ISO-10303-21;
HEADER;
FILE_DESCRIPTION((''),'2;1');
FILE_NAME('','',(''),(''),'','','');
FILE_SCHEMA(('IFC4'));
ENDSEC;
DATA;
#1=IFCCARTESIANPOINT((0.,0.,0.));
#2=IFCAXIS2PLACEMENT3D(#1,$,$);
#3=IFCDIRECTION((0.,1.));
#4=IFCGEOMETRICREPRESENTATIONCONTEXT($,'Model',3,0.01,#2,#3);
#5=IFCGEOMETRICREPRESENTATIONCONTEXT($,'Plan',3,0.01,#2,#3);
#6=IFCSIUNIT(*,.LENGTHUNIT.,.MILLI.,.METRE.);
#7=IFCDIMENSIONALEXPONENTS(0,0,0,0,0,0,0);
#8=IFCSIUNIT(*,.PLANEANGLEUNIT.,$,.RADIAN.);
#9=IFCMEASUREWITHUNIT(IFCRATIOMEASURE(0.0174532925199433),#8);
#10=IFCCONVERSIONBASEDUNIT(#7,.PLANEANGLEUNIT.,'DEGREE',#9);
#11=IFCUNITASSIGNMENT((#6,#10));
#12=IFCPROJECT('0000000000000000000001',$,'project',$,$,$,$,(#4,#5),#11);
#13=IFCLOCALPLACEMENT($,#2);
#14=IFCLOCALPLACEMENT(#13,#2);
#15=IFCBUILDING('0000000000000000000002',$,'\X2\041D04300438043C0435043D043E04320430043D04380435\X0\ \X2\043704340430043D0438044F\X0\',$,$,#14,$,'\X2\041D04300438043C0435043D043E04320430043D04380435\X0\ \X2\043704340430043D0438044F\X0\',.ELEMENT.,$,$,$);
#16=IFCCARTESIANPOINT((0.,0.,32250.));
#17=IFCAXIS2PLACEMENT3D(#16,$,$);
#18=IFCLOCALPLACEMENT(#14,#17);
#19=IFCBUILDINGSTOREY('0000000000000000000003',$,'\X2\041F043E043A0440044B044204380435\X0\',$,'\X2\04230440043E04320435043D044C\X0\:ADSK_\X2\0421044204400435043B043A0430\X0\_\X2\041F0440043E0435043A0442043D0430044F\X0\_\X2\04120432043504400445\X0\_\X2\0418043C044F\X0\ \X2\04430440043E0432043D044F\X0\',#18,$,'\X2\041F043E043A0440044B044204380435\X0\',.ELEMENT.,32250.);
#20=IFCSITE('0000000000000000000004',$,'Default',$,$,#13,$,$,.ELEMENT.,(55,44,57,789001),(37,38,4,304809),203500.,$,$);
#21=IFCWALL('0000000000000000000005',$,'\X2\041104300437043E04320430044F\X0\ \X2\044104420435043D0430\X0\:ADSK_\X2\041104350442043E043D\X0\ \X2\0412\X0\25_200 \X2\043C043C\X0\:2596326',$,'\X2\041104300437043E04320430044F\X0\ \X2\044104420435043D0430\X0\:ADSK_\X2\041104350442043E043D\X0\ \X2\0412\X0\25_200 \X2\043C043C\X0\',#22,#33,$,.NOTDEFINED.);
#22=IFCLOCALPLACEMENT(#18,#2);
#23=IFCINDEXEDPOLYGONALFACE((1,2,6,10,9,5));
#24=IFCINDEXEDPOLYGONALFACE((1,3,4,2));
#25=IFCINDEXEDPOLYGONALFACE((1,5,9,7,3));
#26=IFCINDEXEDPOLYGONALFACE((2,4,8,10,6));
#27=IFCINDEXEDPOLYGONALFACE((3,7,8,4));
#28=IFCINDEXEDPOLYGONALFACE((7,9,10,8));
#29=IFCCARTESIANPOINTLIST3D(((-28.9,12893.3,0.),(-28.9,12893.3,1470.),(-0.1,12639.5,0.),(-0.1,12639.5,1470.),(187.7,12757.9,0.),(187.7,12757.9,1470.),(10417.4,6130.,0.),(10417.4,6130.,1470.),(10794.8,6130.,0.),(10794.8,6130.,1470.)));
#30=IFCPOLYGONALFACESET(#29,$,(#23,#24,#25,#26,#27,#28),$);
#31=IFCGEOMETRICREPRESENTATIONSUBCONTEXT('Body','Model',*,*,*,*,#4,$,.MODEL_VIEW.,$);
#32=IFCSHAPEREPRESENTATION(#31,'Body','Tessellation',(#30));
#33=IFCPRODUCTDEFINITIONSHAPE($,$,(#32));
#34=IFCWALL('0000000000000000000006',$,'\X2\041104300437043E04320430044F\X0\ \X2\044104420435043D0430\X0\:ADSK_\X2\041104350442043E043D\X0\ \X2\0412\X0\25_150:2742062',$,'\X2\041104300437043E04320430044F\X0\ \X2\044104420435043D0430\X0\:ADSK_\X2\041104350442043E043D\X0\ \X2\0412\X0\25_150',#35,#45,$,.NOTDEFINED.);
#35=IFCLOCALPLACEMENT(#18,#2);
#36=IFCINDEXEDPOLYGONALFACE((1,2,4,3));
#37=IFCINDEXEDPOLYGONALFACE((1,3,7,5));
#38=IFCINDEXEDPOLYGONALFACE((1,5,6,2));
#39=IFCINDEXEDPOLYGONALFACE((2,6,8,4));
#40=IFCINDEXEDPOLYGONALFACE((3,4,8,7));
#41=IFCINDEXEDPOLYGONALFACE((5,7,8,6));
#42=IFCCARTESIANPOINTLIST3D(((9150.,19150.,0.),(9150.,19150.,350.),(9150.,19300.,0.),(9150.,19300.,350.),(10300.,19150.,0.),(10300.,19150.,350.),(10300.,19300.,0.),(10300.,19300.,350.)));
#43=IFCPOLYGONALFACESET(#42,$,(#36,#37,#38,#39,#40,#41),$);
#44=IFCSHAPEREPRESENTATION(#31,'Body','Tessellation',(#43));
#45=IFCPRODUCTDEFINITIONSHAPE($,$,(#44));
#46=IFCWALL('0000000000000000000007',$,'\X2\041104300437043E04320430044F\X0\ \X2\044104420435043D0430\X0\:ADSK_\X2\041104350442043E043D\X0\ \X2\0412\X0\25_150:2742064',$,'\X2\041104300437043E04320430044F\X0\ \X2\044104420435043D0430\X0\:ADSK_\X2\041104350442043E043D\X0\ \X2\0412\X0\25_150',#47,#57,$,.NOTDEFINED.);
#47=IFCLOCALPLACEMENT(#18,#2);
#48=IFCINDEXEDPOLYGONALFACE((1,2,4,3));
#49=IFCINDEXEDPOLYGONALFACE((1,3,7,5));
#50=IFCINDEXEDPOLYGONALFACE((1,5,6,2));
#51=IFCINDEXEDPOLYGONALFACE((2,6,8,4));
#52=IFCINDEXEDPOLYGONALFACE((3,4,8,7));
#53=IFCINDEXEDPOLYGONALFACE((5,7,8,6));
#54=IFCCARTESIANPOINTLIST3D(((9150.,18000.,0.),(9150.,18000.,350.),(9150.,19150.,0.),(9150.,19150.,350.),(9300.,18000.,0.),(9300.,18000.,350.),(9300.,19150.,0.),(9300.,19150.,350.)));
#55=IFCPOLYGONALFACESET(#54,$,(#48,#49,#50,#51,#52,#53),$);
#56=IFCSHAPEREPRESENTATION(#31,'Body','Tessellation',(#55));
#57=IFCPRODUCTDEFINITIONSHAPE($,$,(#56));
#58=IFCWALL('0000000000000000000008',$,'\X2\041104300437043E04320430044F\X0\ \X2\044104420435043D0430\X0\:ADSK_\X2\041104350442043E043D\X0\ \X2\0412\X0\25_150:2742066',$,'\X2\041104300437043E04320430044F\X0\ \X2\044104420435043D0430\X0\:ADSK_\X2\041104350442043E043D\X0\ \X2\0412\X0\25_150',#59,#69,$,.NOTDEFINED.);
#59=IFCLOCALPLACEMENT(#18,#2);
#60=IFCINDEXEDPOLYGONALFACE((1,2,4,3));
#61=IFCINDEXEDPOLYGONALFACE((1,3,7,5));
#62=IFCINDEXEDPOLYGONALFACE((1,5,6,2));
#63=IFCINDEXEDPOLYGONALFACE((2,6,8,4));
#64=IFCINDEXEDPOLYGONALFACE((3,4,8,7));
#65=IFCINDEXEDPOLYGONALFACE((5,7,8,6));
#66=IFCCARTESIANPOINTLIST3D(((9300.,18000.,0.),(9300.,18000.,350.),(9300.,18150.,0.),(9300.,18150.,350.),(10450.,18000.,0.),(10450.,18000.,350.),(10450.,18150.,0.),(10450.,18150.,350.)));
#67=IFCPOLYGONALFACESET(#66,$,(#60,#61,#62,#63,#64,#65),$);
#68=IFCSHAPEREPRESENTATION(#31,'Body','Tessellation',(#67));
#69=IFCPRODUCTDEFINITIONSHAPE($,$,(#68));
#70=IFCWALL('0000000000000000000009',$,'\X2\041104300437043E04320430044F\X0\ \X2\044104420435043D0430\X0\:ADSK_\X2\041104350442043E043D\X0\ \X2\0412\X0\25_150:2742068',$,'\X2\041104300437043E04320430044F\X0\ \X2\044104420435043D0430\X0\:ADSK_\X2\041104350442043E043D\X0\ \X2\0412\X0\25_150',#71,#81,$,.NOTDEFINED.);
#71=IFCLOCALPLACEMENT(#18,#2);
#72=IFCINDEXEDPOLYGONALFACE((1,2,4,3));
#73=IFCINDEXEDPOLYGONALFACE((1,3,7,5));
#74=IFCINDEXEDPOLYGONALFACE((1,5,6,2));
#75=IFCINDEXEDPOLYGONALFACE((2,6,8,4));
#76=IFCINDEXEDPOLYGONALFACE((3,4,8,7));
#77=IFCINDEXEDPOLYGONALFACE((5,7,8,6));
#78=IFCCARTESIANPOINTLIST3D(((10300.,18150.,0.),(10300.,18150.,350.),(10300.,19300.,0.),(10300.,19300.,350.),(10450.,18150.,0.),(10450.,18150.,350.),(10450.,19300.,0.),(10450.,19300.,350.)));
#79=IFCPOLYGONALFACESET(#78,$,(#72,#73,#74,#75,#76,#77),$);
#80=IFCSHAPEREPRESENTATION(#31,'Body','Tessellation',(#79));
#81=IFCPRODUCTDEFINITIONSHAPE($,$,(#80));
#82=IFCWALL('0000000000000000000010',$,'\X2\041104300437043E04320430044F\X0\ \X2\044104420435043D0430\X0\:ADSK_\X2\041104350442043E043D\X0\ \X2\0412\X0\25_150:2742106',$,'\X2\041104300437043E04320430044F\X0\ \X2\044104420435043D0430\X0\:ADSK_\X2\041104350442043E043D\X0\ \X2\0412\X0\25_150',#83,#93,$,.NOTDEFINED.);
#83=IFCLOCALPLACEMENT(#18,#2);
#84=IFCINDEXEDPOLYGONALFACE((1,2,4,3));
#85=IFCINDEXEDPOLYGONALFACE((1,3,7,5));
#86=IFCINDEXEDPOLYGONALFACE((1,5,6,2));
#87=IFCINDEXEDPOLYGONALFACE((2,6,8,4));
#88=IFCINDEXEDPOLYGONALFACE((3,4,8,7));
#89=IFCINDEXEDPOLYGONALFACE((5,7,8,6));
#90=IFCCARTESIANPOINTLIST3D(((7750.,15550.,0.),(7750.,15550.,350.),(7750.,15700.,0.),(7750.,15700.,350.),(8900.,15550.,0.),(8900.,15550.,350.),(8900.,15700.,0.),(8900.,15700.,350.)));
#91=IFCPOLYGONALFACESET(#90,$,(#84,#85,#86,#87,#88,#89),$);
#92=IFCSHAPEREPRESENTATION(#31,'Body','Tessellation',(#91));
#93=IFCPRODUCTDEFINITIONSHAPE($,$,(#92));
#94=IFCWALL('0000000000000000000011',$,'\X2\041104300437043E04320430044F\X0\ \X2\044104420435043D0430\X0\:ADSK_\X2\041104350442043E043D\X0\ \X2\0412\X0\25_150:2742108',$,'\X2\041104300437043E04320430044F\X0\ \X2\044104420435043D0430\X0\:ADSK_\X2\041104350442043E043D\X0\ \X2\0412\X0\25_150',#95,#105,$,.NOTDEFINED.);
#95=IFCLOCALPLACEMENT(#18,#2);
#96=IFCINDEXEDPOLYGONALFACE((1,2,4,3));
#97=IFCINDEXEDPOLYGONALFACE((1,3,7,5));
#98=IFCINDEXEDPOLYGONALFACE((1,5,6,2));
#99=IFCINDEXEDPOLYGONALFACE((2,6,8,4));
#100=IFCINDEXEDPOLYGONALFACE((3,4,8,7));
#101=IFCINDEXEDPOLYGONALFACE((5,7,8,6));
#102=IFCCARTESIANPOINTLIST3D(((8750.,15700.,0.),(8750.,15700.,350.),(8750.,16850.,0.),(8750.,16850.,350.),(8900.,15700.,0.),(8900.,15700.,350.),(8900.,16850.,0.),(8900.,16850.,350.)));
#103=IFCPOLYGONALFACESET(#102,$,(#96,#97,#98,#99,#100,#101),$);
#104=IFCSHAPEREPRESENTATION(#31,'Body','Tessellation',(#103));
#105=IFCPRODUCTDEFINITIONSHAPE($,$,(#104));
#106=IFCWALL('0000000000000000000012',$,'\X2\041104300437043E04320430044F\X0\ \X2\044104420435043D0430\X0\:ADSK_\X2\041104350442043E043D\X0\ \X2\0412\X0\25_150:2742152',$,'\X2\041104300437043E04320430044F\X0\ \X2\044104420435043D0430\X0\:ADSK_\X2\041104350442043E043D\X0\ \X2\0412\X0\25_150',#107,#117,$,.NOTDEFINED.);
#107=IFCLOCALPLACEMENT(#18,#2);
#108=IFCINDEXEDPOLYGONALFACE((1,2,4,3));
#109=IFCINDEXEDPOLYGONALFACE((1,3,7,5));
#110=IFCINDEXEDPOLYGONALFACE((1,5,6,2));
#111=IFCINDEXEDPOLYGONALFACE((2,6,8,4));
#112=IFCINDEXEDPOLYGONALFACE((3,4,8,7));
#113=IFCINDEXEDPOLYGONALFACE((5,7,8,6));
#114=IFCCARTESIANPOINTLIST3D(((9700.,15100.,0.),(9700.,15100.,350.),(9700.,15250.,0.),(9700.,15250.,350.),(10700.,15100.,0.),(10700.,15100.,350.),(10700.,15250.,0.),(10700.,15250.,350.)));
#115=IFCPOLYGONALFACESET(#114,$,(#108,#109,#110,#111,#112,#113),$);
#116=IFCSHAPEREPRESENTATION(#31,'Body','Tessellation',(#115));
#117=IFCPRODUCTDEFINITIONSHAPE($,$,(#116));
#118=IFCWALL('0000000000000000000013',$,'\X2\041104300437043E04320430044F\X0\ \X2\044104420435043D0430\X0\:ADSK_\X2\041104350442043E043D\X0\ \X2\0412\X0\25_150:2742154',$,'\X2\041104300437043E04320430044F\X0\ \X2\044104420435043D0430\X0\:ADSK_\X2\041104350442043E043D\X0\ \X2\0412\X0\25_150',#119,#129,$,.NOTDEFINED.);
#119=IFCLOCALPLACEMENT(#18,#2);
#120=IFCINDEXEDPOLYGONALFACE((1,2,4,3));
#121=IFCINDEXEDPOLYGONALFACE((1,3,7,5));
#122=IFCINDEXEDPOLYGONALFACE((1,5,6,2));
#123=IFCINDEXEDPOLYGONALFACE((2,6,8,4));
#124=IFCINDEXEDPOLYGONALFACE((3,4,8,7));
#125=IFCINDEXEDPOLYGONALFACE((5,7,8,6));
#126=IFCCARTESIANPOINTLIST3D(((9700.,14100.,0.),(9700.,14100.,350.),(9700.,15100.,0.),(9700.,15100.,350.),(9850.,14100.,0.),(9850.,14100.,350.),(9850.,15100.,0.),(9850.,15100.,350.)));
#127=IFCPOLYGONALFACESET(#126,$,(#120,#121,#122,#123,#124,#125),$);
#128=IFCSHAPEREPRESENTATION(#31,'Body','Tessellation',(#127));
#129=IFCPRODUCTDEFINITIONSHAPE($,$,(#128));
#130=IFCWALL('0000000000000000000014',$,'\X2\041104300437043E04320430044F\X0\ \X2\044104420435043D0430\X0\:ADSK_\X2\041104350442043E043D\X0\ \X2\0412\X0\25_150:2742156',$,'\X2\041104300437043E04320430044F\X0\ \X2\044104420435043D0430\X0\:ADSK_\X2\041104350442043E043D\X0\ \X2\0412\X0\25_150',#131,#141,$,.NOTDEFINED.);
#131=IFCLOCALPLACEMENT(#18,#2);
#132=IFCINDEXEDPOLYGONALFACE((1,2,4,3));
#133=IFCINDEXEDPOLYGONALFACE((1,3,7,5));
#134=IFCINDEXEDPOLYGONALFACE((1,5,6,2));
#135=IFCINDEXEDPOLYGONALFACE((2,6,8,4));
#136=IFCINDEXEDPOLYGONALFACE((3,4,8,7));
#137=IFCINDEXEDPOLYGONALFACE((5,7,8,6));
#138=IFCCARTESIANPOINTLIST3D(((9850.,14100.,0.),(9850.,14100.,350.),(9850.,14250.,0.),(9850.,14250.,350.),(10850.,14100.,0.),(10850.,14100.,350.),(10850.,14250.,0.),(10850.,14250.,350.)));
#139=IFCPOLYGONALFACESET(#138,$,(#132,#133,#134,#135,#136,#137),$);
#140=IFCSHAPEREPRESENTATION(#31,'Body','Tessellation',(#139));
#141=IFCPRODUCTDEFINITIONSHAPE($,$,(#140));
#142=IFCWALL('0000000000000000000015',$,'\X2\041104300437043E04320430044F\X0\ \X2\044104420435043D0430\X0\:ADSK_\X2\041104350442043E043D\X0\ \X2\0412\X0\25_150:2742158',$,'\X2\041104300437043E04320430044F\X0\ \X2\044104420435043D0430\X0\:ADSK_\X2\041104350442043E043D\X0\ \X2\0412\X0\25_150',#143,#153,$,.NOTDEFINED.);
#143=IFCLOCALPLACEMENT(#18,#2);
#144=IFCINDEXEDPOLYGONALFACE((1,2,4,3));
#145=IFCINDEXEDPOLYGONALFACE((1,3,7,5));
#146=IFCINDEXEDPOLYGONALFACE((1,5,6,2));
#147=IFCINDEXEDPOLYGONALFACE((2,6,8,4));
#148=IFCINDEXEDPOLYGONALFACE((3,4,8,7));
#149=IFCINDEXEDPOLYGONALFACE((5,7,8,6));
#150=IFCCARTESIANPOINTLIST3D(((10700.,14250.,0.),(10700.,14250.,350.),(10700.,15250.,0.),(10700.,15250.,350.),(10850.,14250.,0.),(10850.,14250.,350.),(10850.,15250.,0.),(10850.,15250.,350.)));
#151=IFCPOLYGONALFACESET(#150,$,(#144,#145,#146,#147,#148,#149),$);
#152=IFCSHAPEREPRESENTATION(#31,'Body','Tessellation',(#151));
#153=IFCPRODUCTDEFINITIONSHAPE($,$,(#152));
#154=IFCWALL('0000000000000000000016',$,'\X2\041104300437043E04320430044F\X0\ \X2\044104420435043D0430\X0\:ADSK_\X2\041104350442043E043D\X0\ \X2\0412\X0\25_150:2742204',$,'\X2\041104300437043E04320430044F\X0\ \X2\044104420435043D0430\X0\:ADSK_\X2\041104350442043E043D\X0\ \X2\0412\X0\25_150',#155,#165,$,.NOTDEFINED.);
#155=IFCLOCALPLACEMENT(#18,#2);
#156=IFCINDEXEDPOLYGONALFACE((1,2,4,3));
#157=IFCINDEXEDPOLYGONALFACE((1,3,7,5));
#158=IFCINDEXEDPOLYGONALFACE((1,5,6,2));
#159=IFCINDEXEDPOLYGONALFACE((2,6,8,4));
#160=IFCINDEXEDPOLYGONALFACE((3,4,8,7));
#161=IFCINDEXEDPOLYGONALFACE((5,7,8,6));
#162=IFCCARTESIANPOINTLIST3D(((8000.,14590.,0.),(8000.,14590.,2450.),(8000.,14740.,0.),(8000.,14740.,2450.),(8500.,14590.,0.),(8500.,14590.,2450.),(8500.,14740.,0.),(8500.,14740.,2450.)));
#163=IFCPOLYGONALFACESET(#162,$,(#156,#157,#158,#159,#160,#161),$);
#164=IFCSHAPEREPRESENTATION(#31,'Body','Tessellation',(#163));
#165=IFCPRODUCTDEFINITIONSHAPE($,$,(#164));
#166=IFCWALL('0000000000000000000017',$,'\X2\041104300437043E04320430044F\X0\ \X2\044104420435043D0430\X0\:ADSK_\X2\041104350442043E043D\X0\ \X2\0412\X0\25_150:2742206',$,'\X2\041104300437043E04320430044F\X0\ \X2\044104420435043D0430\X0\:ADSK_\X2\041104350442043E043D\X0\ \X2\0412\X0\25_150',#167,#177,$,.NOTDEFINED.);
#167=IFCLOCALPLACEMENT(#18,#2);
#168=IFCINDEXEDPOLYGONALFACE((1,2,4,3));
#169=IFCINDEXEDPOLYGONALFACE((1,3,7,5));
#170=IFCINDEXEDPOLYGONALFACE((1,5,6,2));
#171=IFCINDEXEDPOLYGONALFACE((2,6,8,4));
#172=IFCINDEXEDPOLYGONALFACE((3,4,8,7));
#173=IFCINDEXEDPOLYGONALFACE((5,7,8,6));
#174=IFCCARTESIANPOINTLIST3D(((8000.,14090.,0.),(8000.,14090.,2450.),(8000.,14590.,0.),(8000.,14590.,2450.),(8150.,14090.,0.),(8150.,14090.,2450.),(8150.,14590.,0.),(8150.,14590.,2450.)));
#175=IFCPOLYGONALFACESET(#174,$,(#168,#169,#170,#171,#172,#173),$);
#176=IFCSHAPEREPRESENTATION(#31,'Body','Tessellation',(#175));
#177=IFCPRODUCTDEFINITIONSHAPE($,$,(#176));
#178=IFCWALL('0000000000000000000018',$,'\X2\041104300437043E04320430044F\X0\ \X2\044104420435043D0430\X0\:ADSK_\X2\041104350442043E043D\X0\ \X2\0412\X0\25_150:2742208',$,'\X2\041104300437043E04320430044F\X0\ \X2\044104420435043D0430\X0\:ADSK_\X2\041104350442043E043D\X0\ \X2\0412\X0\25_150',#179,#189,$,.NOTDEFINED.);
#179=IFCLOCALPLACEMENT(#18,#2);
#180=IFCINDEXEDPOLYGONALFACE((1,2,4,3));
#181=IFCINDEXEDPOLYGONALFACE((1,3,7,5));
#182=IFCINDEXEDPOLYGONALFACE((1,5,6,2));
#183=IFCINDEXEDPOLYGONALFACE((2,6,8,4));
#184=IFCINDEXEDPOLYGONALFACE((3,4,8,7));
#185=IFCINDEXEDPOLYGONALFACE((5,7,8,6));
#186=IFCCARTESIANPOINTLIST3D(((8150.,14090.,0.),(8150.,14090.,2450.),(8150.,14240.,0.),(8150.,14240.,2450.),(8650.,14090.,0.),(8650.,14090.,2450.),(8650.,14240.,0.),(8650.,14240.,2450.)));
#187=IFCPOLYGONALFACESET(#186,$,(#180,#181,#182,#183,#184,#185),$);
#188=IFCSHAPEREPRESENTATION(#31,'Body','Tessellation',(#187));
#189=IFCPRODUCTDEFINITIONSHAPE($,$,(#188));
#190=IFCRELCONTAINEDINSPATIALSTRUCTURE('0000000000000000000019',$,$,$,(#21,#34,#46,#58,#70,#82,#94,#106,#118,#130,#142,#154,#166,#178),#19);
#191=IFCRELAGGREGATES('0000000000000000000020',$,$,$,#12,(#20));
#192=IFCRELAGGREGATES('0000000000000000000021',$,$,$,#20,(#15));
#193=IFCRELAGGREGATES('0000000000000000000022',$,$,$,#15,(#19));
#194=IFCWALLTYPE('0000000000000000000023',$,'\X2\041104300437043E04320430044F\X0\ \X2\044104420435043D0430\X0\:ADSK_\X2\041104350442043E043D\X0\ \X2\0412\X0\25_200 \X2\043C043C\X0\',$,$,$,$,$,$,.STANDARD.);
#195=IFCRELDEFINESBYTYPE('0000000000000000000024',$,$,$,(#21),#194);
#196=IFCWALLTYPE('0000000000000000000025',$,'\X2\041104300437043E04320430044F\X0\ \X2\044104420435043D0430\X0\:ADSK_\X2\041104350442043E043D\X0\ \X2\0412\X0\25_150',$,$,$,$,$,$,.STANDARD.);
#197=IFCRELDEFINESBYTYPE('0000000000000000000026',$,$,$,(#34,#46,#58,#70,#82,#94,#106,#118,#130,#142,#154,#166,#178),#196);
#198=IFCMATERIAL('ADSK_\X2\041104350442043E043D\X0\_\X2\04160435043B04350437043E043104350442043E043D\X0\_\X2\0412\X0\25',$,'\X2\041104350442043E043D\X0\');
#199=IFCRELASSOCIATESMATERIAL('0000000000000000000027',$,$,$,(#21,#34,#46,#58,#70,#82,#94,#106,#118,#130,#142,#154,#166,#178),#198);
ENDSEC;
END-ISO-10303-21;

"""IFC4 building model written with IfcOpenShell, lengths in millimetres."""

from ifc_helpers import new_model, entity, si_unit, converted_unit, direction, frame, origin, place, context, subcontext, project, spatial, indexed_curve, outline, extrude, material, type_object, element, save


model = new_model("IFC4")

# Units and contexts
model_context = context("Model", 3, precision=0.01, world=origin(), true_north=direction((0.0, 1.0)))
plan_context = context("Plan", 3, precision=0.01, world=origin(), true_north=direction((0.0, 1.0)))
body_context = subcontext(model_context, "Body", "Model", "MODEL_VIEW")
ifc_project = project(units=[si_unit("LENGTHUNIT", "METRE", prefix="MILLI"), converted_unit("PLANEANGLEUNIT", "DEGREE", entity("IfcRatioMeasure", 0.0174532925199433), si_unit("PLANEANGLEUNIT", "RADIAN"), dimensions=[0, 0, 0, 0, 0, 0, 0])], contexts=[model_context, plan_context])

# Site, building, storey
site_placement = place(None, origin())
site = spatial("IfcSite", under=ifc_project, at=site_placement, Name="Default", CompositionType="ELEMENT", RefLatitude=(55, 44, 57, 789001), RefLongitude=(37, 38, 4, 304809), RefElevation=203500.0)
building_placement = place(site_placement, origin())
building = spatial("IfcBuilding", under=site, at=building_placement, Name="Наименование здания", LongName="Наименование здания", CompositionType="ELEMENT")
storey_placement = place(building_placement, frame((0.0, 0.0, 32250.0)))
storey = spatial("IfcBuildingStorey", under=building, at=storey_placement, Name="Покрытие", ObjectType="Уровень:ADSK_Стрелка_Проектная_Вверх_Имя уровня", LongName="Покрытие", CompositionType="ELEMENT", Elevation=32250.0)

# Walls
ifc_material = material(Name="ADSK_Бетон_Железобетон_В25", Category="Бетон")
wall_type_1 = type_object("IfcWallType", Name="Базовая стена:ADSK_Бетон В25_200 мм", PredefinedType="STANDARD")
wall_1_placement = place(storey_placement, frame((10741.8, 6045.2, 0.0), z_axis=(0.0, 0.0, 1.0), x_axis=(-0.848053, 0.529912, 0.0)))
element("IfcWall", 1, at=wall_1_placement, inside=storey, type_object=wall_type_1, material=ifc_material, Name="Базовая стена:ADSK_Бетон В25_200 мм:2596326", ObjectType="Базовая стена:ADSK_Бетон В25_200 мм", PredefinedType="NOTDEFINED", context=body_context, shape_type="SweptSolid", body=[
    extrude(outline(indexed_curve([(12763.1, -100.0), (12604.1, 100.0), (320.1, 100.0), (0.0, -100.0), (12507.6, -100.0), (12763.1, -100.0)], self_intersect=False)), origin(), (0.0, 0.0, 1.0), 1470.0),
])
wall_type_2 = type_object("IfcWallType", Name="Базовая стена:ADSK_Бетон В25_150", PredefinedType="STANDARD")
wall_2_placement = place(storey_placement, frame((9150.0, 19225.0, 0.0)))
element("IfcWall", 2, at=wall_2_placement, inside=storey, type_object=wall_type_2, material=ifc_material, Name="Базовая стена:ADSK_Бетон В25_150:2742062", ObjectType="Базовая стена:ADSK_Бетон В25_150", PredefinedType="NOTDEFINED", context=body_context, shape_type="SweptSolid", body=[
    extrude(outline(indexed_curve([(1150.0, 75.0), (0.0, 75.0), (0.0, -75.0), (1150.0, -75.0), (1150.0, 75.0)], self_intersect=False)), origin(), (0.0, 0.0, 1.0), 350.0),
])
wall_3_placement = place(storey_placement, frame((9225.0, 18000.0, 0.0), z_axis=(0.0, 0.0, 1.0), x_axis=(0.0, 1.0, 0.0)))
element("IfcWall", 3, at=wall_3_placement, inside=storey, type_object=wall_type_2, material=ifc_material, Name="Базовая стена:ADSK_Бетон В25_150:2742064", ObjectType="Базовая стена:ADSK_Бетон В25_150", PredefinedType="NOTDEFINED", context=body_context, shape_type="SweptSolid", body=[
    extrude(outline(indexed_curve([(1150.0, 75.0), (0.0, 75.0), (0.0, -75.0), (1150.0, -75.0), (1150.0, 75.0)], self_intersect=False)), origin(), (0.0, 0.0, 1.0), 350.0),
])
wall_4_placement = place(storey_placement, frame((10450.0, 18075.0, 0.0), z_axis=(0.0, 0.0, 1.0), x_axis=(-1.0, 0.0, 0.0)))
element("IfcWall", 4, at=wall_4_placement, inside=storey, type_object=wall_type_2, material=ifc_material, Name="Базовая стена:ADSK_Бетон В25_150:2742066", ObjectType="Базовая стена:ADSK_Бетон В25_150", PredefinedType="NOTDEFINED", context=body_context, shape_type="SweptSolid", body=[
    extrude(outline(indexed_curve([(1150.0, 75.0), (0.0, 75.0), (0.0, -75.0), (1150.0, -75.0), (1150.0, 75.0)], self_intersect=False)), origin(), (0.0, 0.0, 1.0), 350.0),
])
wall_5_placement = place(storey_placement, frame((10375.0, 19300.0, 0.0), z_axis=(0.0, 0.0, 1.0), x_axis=(0.0, -1.0, 0.0)))
element("IfcWall", 5, at=wall_5_placement, inside=storey, type_object=wall_type_2, material=ifc_material, Name="Базовая стена:ADSK_Бетон В25_150:2742068", ObjectType="Базовая стена:ADSK_Бетон В25_150", PredefinedType="NOTDEFINED", context=body_context, shape_type="SweptSolid", body=[
    extrude(outline(indexed_curve([(1150.0, 75.0), (0.0, 75.0), (0.0, -75.0), (1150.0, -75.0), (1150.0, 75.0)], self_intersect=False)), origin(), (0.0, 0.0, 1.0), 350.0),
])
for number, where, z_axis, x_axis, name in (
    (6, (8900.0, 15625.0, 0.0), (0.0, 0.0, 1.0), (-1.0, 0.0, 0.0), "Базовая стена:ADSK_Бетон В25_150:2742106"),
    (7, (8825.0, 16850.0, 0.0), (0.0, 0.0, 1.0), (0.0, -1.0, 0.0), "Базовая стена:ADSK_Бетон В25_150:2742108"),
):
    element("IfcWall", number, at=place(storey_placement, frame(where, z_axis=z_axis, x_axis=x_axis)), inside=storey, type_object=wall_type_2, material=ifc_material, Name=name, ObjectType="Базовая стена:ADSK_Бетон В25_150", PredefinedType="NOTDEFINED", context=body_context, shape_type="SweptSolid", body=[
        extrude(outline(indexed_curve([(1150.0, 75.0), (0.0, 75.0), (0.0, -75.0), (1150.0, -75.0), (1150.0, 75.0)], self_intersect=False)), origin(), (0.0, 0.0, 1.0), 350.0),
    ])
wall_6_placement = place(storey_placement, frame((9700.0, 15175.0, 0.0)))
element("IfcWall", 8, at=wall_6_placement, inside=storey, type_object=wall_type_2, material=ifc_material, Name="Базовая стена:ADSK_Бетон В25_150:2742152", ObjectType="Базовая стена:ADSK_Бетон В25_150", PredefinedType="NOTDEFINED", context=body_context, shape_type="SweptSolid", body=[
    extrude(outline(indexed_curve([(1000.0, 75.0), (0.0, 75.0), (0.0, -75.0), (1000.0, -75.0), (1000.0, 75.0)], self_intersect=False)), origin(), (0.0, 0.0, 1.0), 350.0),
])
wall_7_placement = place(storey_placement, frame((9775.0, 14100.0, 0.0), z_axis=(0.0, 0.0, 1.0), x_axis=(0.0, 1.0, 0.0)))
element("IfcWall", 9, at=wall_7_placement, inside=storey, type_object=wall_type_2, material=ifc_material, Name="Базовая стена:ADSK_Бетон В25_150:2742154", ObjectType="Базовая стена:ADSK_Бетон В25_150", PredefinedType="NOTDEFINED", context=body_context, shape_type="SweptSolid", body=[
    extrude(outline(indexed_curve([(1000.0, 75.0), (0.0, 75.0), (0.0, -75.0), (1000.0, -75.0), (1000.0, 75.0)], self_intersect=False)), origin(), (0.0, 0.0, 1.0), 350.0),
])
wall_8_placement = place(storey_placement, frame((10850.0, 14175.0, 0.0), z_axis=(0.0, 0.0, 1.0), x_axis=(-1.0, 0.0, 0.0)))
element("IfcWall", 10, at=wall_8_placement, inside=storey, type_object=wall_type_2, material=ifc_material, Name="Базовая стена:ADSK_Бетон В25_150:2742156", ObjectType="Базовая стена:ADSK_Бетон В25_150", PredefinedType="NOTDEFINED", context=body_context, shape_type="SweptSolid", body=[
    extrude(outline(indexed_curve([(1000.0, 75.0), (0.0, 75.0), (0.0, -75.0), (1000.0, -75.0), (1000.0, 75.0)], self_intersect=False)), origin(), (0.0, 0.0, 1.0), 350.0),
])
wall_9_placement = place(storey_placement, frame((10775.0, 15250.0, 0.0), z_axis=(0.0, 0.0, 1.0), x_axis=(0.0, -1.0, 0.0)))
element("IfcWall", 11, at=wall_9_placement, inside=storey, type_object=wall_type_2, material=ifc_material, Name="Базовая стена:ADSK_Бетон В25_150:2742158", ObjectType="Базовая стена:ADSK_Бетон В25_150", PredefinedType="NOTDEFINED", context=body_context, shape_type="SweptSolid", body=[
    extrude(outline(indexed_curve([(1000.0, 75.0), (0.0, 75.0), (0.0, -75.0), (1000.0, -75.0), (1000.0, 75.0)], self_intersect=False)), origin(), (0.0, 0.0, 1.0), 350.0),
])
wall_10_placement = place(storey_placement, frame((8000.0, 14665.0, 0.0)))
element("IfcWall", 12, at=wall_10_placement, inside=storey, type_object=wall_type_2, material=ifc_material, Name="Базовая стена:ADSK_Бетон В25_150:2742204", ObjectType="Базовая стена:ADSK_Бетон В25_150", PredefinedType="NOTDEFINED", context=body_context, shape_type="SweptSolid", body=[
    extrude(outline(indexed_curve([(500.0, 75.0), (0.0, 75.0), (0.0, -75.0), (500.0, -75.0), (500.0, 75.0)], self_intersect=False)), origin(), (0.0, 0.0, 1.0), 2450.0),
])
for number, where, z_axis, x_axis, name in (
    (13, (8075.0, 14090.0, 0.0), (0.0, 0.0, 1.0), (0.0, 1.0, 0.0), "Базовая стена:ADSK_Бетон В25_150:2742206"),
    (14, (8650.0, 14165.0, 0.0), (0.0, 0.0, 1.0), (-1.0, 0.0, 0.0), "Базовая стена:ADSK_Бетон В25_150:2742208"),
):
    element("IfcWall", number, at=place(storey_placement, frame(where, z_axis=z_axis, x_axis=x_axis)), inside=storey, type_object=wall_type_2, material=ifc_material, Name=name, ObjectType="Базовая стена:ADSK_Бетон В25_150", PredefinedType="NOTDEFINED", context=body_context, shape_type="SweptSolid", body=[
        extrude(outline(indexed_curve([(500.0, 75.0), (0.0, 75.0), (0.0, -75.0), (500.0, -75.0), (500.0, 75.0)], self_intersect=False)), origin(), (0.0, 0.0, 1.0), 2450.0),
    ])

save(model, "model.ifc")
